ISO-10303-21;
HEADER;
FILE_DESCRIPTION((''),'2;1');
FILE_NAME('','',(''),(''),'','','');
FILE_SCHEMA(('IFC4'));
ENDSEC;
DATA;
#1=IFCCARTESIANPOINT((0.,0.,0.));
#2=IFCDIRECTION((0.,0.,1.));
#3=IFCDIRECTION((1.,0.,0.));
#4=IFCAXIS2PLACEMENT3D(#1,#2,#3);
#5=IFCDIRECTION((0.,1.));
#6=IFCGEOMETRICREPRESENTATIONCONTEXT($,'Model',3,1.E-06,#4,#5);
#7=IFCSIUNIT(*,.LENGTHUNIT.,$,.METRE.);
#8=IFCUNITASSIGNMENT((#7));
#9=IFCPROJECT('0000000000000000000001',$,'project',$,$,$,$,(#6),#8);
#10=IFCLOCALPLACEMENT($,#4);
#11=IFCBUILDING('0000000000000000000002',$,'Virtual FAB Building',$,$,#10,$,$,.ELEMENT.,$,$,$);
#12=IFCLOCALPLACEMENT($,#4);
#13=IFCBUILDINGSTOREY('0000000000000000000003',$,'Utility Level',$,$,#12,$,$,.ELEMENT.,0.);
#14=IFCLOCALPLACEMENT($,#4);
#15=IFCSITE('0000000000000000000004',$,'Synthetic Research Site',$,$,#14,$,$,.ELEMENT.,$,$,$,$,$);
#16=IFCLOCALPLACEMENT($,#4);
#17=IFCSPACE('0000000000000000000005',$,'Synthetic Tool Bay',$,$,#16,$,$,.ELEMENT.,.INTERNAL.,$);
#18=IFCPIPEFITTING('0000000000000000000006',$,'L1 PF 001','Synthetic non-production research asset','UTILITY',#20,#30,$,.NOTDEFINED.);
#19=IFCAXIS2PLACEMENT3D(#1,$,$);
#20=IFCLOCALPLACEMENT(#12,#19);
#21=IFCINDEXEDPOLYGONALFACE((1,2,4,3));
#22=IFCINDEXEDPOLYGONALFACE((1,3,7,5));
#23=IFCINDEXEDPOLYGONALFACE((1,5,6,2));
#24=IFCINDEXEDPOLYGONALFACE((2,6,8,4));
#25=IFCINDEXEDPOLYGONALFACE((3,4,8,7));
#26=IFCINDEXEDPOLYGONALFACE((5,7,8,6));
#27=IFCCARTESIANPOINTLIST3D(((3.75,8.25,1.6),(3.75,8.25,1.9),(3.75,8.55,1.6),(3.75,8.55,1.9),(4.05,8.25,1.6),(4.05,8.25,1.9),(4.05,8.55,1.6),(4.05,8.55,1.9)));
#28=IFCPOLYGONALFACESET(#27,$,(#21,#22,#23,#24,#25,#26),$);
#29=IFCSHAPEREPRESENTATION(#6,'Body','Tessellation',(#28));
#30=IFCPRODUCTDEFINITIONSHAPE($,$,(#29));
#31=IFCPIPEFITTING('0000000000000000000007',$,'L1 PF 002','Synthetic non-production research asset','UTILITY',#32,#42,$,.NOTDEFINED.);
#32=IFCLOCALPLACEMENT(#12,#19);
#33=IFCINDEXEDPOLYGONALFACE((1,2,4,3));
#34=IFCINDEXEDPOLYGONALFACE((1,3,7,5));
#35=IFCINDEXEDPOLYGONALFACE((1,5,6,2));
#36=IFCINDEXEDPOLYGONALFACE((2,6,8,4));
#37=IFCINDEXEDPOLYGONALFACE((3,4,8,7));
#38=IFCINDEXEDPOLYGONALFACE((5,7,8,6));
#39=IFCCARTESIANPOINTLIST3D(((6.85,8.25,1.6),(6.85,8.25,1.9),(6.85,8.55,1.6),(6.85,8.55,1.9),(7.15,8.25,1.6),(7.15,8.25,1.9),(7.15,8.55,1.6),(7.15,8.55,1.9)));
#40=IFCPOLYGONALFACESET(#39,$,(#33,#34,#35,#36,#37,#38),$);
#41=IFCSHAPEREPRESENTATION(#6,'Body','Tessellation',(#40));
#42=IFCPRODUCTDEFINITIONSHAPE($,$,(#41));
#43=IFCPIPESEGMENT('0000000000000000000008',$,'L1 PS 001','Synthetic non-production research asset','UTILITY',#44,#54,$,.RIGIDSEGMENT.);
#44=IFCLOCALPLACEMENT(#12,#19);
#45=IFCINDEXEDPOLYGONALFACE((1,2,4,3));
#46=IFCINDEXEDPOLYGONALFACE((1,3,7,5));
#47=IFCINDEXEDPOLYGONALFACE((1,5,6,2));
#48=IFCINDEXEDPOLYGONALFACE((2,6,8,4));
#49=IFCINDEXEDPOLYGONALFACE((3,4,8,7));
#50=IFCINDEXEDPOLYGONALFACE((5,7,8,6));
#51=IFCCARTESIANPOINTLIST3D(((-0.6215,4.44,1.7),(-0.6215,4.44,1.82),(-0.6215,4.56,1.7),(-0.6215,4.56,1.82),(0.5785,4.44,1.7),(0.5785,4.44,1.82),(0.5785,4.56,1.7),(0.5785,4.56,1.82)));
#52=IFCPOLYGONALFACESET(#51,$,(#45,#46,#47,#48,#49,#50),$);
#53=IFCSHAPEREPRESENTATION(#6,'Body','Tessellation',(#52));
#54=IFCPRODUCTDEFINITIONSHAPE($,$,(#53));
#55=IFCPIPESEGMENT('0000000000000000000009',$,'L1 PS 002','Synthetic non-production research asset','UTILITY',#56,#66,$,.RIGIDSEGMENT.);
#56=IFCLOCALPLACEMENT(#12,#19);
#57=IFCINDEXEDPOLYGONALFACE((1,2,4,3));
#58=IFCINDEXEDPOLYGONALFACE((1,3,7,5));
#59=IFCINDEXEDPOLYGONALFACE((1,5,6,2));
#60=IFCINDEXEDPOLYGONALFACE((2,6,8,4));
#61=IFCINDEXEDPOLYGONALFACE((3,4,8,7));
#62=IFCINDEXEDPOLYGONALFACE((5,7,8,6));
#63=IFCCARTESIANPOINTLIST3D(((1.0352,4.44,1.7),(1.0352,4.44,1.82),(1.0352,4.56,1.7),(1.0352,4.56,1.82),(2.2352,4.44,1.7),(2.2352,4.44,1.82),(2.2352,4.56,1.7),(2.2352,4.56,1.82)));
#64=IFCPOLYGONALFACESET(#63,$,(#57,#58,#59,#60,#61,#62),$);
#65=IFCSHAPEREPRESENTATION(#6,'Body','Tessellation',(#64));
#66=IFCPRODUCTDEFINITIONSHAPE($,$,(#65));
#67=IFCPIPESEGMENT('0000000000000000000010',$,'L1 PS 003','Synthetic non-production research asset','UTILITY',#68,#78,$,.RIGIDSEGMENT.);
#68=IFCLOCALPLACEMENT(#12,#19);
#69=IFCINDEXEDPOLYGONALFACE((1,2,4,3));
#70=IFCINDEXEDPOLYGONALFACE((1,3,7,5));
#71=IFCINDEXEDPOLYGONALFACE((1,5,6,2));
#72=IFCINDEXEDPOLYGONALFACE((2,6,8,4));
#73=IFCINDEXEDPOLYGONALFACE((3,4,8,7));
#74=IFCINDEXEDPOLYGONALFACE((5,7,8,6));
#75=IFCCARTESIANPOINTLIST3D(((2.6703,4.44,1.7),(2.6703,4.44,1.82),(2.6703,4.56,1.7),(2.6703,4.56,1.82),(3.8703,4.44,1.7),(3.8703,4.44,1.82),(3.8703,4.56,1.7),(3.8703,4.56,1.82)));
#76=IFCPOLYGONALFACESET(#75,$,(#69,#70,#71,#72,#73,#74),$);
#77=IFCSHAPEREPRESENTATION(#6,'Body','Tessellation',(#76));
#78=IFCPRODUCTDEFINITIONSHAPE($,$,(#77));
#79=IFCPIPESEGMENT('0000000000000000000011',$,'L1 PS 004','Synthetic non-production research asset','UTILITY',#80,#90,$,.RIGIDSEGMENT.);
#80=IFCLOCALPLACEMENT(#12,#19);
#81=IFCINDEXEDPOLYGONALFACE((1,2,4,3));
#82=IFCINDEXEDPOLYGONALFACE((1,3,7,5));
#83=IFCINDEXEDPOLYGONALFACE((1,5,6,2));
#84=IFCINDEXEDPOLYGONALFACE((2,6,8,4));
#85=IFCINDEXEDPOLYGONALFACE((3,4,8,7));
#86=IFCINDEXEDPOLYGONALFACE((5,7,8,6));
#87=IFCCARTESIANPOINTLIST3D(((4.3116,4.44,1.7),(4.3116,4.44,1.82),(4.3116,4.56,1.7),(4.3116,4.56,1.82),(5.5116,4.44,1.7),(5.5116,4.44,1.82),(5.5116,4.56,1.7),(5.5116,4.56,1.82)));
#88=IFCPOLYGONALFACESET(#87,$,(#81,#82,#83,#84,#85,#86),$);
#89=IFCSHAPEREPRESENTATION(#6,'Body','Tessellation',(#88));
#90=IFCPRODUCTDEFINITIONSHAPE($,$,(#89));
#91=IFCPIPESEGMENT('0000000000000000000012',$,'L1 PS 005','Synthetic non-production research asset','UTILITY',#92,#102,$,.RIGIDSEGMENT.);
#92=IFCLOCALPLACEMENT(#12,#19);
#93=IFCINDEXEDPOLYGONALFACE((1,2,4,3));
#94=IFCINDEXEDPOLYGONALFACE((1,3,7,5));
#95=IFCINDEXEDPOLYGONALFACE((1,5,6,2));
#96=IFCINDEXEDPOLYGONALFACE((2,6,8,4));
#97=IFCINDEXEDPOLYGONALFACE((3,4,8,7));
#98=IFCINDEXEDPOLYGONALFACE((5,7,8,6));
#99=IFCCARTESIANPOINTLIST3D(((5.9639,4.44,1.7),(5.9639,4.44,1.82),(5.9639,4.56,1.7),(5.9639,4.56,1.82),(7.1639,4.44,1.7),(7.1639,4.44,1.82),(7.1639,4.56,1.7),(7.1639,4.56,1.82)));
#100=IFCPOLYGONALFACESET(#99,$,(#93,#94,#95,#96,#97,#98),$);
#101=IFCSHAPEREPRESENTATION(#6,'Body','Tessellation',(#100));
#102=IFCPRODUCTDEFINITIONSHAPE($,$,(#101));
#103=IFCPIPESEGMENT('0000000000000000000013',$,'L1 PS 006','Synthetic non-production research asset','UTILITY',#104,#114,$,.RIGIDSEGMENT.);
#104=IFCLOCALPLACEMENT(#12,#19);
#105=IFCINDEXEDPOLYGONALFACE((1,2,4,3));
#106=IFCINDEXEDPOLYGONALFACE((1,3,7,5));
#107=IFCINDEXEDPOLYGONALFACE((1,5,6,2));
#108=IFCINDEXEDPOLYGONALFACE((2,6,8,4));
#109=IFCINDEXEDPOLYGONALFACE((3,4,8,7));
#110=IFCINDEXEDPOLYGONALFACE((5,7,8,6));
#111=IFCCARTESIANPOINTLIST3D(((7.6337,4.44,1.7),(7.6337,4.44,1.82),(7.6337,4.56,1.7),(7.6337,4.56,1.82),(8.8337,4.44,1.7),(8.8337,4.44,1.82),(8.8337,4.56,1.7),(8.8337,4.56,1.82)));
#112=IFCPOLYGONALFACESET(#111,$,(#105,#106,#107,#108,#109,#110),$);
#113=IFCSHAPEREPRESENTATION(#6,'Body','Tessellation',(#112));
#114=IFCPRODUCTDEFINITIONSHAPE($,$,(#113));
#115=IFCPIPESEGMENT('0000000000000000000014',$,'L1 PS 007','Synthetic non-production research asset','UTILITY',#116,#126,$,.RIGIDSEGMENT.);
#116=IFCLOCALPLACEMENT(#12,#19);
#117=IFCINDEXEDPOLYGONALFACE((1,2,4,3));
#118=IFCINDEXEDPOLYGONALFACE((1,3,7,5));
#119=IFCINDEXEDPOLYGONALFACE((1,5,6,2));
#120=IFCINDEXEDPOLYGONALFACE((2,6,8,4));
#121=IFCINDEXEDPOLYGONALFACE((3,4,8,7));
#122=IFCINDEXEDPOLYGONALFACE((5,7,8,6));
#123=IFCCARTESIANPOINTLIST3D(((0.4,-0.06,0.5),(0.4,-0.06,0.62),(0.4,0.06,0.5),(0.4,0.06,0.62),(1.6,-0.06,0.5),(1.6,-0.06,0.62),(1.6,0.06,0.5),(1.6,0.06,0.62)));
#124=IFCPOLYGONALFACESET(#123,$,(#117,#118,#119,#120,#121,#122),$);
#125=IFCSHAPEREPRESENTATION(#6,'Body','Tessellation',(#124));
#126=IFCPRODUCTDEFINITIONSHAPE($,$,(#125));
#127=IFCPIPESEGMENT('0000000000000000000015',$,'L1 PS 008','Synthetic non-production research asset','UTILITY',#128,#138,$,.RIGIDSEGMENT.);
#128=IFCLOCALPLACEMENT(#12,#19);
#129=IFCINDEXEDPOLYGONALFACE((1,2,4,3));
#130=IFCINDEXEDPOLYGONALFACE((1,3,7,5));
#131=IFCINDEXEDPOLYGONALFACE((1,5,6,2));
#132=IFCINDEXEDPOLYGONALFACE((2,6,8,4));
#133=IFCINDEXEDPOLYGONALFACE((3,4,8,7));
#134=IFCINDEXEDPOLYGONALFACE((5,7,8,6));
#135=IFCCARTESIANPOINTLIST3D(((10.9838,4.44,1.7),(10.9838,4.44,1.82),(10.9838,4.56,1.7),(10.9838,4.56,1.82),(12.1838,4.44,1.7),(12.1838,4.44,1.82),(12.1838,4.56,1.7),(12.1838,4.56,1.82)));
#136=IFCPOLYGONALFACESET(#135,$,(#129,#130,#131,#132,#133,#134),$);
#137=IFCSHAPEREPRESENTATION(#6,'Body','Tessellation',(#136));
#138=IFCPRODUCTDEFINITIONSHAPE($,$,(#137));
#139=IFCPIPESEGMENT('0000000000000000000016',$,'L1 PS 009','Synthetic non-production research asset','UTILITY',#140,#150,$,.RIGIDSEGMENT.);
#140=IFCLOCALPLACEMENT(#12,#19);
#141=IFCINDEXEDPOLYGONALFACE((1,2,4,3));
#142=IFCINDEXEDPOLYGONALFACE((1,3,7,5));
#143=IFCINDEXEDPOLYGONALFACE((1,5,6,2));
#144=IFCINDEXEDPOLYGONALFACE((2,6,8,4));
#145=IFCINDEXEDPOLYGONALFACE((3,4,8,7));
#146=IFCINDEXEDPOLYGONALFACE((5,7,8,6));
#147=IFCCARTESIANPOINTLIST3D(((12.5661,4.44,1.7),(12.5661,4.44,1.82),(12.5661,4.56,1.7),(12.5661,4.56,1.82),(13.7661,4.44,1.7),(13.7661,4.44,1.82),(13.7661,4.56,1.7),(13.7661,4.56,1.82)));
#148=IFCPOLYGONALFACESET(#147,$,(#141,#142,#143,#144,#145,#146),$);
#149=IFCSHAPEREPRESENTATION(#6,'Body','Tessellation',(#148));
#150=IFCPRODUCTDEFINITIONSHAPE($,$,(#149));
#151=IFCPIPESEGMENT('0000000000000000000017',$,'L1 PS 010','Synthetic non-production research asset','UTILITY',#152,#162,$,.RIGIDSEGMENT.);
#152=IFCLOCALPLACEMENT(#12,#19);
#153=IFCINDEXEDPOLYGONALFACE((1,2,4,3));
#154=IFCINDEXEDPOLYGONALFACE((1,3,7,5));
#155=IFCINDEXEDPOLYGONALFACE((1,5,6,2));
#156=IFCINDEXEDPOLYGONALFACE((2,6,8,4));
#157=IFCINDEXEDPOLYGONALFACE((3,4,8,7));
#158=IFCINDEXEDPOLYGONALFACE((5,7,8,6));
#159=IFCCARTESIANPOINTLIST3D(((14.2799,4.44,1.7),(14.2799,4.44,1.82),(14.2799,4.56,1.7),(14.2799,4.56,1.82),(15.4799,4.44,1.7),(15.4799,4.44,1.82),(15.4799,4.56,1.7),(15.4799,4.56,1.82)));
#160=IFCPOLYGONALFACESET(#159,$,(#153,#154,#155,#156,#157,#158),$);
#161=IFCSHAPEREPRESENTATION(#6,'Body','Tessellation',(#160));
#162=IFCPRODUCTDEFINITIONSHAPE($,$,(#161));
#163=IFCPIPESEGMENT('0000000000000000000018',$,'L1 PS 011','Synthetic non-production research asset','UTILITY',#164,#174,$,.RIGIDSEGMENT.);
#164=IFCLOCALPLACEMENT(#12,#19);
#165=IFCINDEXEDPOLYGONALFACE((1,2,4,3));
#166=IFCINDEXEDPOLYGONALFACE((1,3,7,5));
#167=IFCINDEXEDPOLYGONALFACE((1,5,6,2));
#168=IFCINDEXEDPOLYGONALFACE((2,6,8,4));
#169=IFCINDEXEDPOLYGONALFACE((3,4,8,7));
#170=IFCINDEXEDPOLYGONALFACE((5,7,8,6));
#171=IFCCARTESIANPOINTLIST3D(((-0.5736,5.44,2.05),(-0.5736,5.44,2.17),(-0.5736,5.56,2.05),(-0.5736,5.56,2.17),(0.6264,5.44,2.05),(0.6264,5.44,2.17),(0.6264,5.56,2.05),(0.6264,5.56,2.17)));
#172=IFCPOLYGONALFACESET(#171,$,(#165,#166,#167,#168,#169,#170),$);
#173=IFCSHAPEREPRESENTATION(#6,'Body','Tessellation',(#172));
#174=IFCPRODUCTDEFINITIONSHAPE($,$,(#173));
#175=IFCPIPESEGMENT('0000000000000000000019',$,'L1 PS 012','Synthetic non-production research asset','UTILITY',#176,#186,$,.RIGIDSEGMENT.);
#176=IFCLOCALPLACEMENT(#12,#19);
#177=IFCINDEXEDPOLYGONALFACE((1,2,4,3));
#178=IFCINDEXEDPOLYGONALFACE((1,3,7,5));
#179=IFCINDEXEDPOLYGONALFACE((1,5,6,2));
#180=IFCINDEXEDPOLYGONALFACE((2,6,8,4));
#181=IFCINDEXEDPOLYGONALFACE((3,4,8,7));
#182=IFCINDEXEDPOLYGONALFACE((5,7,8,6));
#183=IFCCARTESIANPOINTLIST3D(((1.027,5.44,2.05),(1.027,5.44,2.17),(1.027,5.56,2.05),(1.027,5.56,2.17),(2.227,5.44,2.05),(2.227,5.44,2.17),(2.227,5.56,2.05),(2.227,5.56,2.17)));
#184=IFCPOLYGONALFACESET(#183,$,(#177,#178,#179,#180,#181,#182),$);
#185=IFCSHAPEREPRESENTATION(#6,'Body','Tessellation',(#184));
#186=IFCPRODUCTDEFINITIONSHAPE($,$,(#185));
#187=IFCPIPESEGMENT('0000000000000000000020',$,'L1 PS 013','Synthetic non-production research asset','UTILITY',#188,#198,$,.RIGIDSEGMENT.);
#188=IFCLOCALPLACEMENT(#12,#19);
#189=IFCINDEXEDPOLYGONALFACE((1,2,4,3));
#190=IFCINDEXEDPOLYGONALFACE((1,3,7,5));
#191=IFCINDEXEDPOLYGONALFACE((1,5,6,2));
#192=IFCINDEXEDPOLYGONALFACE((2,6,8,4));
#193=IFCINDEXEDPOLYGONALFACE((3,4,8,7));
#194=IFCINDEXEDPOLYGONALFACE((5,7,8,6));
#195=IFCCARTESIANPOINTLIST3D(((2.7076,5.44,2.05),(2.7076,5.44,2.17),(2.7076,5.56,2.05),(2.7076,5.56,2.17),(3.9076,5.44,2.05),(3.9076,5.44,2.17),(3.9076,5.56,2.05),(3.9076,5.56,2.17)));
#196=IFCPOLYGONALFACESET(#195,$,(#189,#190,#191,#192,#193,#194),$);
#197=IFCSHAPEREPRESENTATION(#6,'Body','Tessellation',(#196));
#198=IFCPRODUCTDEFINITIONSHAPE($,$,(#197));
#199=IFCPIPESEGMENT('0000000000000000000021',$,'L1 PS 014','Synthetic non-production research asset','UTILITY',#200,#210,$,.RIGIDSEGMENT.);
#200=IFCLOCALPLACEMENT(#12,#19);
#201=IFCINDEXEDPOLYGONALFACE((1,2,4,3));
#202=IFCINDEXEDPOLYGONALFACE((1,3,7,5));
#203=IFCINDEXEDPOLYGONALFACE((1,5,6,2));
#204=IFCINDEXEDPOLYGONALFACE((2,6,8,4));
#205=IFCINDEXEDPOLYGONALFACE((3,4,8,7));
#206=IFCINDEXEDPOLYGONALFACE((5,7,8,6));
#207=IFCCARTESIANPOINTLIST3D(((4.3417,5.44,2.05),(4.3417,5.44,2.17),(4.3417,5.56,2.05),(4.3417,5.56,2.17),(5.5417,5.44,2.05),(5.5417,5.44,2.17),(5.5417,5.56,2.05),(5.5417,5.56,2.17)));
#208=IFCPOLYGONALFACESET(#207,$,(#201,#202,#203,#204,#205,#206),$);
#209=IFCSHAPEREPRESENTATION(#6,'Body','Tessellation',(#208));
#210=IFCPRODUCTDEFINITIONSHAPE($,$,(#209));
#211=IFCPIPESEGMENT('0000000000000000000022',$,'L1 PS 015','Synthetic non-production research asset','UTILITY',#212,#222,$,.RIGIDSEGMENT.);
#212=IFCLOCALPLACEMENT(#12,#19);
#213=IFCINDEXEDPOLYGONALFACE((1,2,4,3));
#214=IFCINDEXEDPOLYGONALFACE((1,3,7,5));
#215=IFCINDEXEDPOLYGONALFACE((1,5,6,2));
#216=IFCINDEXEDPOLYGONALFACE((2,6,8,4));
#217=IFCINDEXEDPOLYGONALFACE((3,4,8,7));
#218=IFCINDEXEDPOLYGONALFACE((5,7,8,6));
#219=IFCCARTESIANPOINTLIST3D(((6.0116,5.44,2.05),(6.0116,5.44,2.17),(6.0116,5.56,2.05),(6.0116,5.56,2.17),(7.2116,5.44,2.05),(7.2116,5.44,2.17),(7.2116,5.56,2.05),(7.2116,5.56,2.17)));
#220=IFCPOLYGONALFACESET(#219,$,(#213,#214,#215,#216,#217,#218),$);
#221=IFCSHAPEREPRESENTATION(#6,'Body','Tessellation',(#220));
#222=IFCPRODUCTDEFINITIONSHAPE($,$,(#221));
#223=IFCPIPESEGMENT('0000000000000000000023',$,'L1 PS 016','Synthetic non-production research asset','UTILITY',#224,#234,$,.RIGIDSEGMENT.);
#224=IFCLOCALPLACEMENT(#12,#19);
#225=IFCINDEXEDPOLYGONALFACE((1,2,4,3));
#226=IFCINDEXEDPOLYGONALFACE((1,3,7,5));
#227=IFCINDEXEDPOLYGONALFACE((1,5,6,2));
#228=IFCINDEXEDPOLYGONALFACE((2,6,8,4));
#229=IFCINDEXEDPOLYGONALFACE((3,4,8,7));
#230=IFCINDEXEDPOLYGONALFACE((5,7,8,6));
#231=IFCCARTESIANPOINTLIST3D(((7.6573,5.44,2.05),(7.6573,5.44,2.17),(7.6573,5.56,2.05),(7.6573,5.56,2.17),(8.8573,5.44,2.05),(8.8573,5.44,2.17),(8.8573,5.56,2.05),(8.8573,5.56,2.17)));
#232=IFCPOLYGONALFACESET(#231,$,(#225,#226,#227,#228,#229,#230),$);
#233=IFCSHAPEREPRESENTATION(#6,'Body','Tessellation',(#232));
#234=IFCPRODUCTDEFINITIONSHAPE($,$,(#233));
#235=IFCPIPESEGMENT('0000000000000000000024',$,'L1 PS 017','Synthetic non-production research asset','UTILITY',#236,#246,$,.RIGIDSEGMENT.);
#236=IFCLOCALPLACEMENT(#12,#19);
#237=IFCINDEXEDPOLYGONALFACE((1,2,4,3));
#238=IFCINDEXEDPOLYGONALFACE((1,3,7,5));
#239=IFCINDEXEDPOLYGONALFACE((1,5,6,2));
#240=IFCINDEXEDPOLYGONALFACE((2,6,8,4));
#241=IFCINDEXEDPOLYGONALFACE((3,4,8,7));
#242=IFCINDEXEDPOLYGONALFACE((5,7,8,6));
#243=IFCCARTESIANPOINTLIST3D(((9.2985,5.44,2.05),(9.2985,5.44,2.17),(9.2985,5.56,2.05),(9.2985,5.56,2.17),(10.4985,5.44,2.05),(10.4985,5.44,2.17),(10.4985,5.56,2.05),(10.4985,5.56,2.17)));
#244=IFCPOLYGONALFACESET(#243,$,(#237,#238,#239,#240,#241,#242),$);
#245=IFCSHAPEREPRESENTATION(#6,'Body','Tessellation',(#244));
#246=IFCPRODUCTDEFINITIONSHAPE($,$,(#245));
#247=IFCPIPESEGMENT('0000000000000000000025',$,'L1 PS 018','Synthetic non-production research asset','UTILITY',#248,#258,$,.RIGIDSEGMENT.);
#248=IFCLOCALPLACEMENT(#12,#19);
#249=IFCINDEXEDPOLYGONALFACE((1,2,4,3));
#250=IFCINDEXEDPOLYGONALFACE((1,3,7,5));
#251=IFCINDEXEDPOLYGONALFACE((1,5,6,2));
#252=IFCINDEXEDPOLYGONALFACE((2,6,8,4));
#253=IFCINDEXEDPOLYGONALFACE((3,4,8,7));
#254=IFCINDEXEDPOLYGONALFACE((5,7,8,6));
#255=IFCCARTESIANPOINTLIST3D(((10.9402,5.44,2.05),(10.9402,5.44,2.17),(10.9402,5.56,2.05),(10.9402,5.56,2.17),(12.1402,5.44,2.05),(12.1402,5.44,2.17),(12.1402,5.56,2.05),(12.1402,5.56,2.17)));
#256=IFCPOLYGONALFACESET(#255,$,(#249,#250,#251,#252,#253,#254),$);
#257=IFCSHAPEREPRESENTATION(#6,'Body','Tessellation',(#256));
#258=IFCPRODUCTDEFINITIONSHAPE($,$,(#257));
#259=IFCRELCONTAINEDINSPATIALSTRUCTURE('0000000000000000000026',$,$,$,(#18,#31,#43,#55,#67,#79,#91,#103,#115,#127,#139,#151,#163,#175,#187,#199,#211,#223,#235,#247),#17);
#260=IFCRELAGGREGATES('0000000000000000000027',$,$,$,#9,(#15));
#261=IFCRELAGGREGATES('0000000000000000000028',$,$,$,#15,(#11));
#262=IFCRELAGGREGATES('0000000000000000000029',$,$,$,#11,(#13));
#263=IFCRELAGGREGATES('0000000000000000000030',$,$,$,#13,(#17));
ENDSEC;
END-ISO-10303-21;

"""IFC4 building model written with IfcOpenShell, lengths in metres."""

from ifc_helpers import new_model, si_unit, direction, frame, origin_with_axes, origin_2d_with_axis, place, context, project, spatial, rectangle, extrude, element, save


model = new_model("IFC4")

# Units and contexts
model_context = context("Model", 3, precision=1e-06, world=origin_with_axes(), true_north=direction((0.0, 1.0)))
ifc_project = project(units=[si_unit("LENGTHUNIT", "METRE")], contexts=[model_context])

# Site, building, storey, space
site_placement = place(None, origin_with_axes())
site = spatial("IfcSite", under=ifc_project, at=site_placement, Name="Synthetic Research Site", CompositionType="ELEMENT")
building_placement = place(None, origin_with_axes())
building = spatial("IfcBuilding", under=site, at=building_placement, Name="Virtual FAB Building", CompositionType="ELEMENT")
storey_placement = place(None, origin_with_axes())
storey = spatial("IfcBuildingStorey", under=building, at=storey_placement, Name="Utility Level", CompositionType="ELEMENT", Elevation=0.0)
space_placement = place(None, origin_with_axes())
space = spatial("IfcSpace", under=storey, at=space_placement, Name="Synthetic Tool Bay", CompositionType="ELEMENT", PredefinedType="INTERNAL")

# Pipe fittings
for number, where, z_axis, x_axis, name in (
    (1, (3.9, 8.4, 1.6), (0.0, 0.0, 1.0), (1.0, 0.0, 0.0), "L1 PF 001"),
    (2, (7.0, 8.4, 1.6), (0.0, 0.0, 1.0), (1.0, 0.0, 0.0), "L1 PF 002"),
):
    element("IfcPipeFitting", number, at=place(None, frame(where, z_axis=z_axis, x_axis=x_axis)), inside=space, Name=name, Description="Synthetic non-production research asset", ObjectType="UTILITY", PredefinedType="NOTDEFINED", context=model_context, shape_type="SweptSolid", body=[
        extrude(rectangle(XDim=0.3, YDim=0.3, at=origin_2d_with_axis()), origin_with_axes(), (0.0, 0.0, 1.0), 0.3),
    ])

# Pipe segments
for number, where, z_axis, x_axis, name in (
    (3, (-0.0215, 4.5, 1.7), (0.0, 0.0, 1.0), (1.0, 0.0, 0.0), "L1 PS 001"),
    (4, (1.6352, 4.5, 1.7), (0.0, 0.0, 1.0), (1.0, 0.0, 0.0), "L1 PS 002"),
    (5, (3.2703, 4.5, 1.7), (0.0, 0.0, 1.0), (1.0, 0.0, 0.0), "L1 PS 003"),
    (6, (4.9116, 4.5, 1.7), (0.0, 0.0, 1.0), (1.0, 0.0, 0.0), "L1 PS 004"),
    (7, (6.5639, 4.5, 1.7), (0.0, 0.0, 1.0), (1.0, 0.0, 0.0), "L1 PS 005"),
    (8, (8.2337, 4.5, 1.7), (0.0, 0.0, 1.0), (1.0, 0.0, 0.0), "L1 PS 006"),
    (9, (1.0, 0.0, 0.5), (0.0, 0.0, 1.0), (1.0, 0.0, 0.0), "L1 PS 007"),
    (10, (11.5838, 4.5, 1.7), (0.0, 0.0, 1.0), (1.0, 0.0, 0.0), "L1 PS 008"),
    (11, (13.1661, 4.5, 1.7), (0.0, 0.0, 1.0), (1.0, 0.0, 0.0), "L1 PS 009"),
    (12, (14.8799, 4.5, 1.7), (0.0, 0.0, 1.0), (1.0, 0.0, 0.0), "L1 PS 010"),
    (13, (0.0264, 5.5, 2.05), (0.0, 0.0, 1.0), (1.0, 0.0, 0.0), "L1 PS 011"),
    (14, (1.627, 5.5, 2.05), (0.0, 0.0, 1.0), (1.0, 0.0, 0.0), "L1 PS 012"),
    (15, (3.3076, 5.5, 2.05), (0.0, 0.0, 1.0), (1.0, 0.0, 0.0), "L1 PS 013"),
    (16, (4.9417, 5.5, 2.05), (0.0, 0.0, 1.0), (1.0, 0.0, 0.0), "L1 PS 014"),
    (17, (6.6116, 5.5, 2.05), (0.0, 0.0, 1.0), (1.0, 0.0, 0.0), "L1 PS 015"),
    (18, (8.2573, 5.5, 2.05), (0.0, 0.0, 1.0), (1.0, 0.0, 0.0), "L1 PS 016"),
    (19, (9.8985, 5.5, 2.05), (0.0, 0.0, 1.0), (1.0, 0.0, 0.0), "L1 PS 017"),
    (20, (11.5402, 5.5, 2.05), (0.0, 0.0, 1.0), (1.0, 0.0, 0.0), "L1 PS 018"),
):
    element("IfcPipeSegment", number, at=place(None, frame(where, z_axis=z_axis, x_axis=x_axis)), inside=space, Name=name, Description="Synthetic non-production research asset", ObjectType="UTILITY", PredefinedType="RIGIDSEGMENT", context=model_context, shape_type="SweptSolid", body=[
        extrude(rectangle(XDim=1.2, YDim=0.12, at=origin_2d_with_axis()), origin_with_axes(), (0.0, 0.0, 1.0), 0.12),
    ])

save(model, "model.ifc")
